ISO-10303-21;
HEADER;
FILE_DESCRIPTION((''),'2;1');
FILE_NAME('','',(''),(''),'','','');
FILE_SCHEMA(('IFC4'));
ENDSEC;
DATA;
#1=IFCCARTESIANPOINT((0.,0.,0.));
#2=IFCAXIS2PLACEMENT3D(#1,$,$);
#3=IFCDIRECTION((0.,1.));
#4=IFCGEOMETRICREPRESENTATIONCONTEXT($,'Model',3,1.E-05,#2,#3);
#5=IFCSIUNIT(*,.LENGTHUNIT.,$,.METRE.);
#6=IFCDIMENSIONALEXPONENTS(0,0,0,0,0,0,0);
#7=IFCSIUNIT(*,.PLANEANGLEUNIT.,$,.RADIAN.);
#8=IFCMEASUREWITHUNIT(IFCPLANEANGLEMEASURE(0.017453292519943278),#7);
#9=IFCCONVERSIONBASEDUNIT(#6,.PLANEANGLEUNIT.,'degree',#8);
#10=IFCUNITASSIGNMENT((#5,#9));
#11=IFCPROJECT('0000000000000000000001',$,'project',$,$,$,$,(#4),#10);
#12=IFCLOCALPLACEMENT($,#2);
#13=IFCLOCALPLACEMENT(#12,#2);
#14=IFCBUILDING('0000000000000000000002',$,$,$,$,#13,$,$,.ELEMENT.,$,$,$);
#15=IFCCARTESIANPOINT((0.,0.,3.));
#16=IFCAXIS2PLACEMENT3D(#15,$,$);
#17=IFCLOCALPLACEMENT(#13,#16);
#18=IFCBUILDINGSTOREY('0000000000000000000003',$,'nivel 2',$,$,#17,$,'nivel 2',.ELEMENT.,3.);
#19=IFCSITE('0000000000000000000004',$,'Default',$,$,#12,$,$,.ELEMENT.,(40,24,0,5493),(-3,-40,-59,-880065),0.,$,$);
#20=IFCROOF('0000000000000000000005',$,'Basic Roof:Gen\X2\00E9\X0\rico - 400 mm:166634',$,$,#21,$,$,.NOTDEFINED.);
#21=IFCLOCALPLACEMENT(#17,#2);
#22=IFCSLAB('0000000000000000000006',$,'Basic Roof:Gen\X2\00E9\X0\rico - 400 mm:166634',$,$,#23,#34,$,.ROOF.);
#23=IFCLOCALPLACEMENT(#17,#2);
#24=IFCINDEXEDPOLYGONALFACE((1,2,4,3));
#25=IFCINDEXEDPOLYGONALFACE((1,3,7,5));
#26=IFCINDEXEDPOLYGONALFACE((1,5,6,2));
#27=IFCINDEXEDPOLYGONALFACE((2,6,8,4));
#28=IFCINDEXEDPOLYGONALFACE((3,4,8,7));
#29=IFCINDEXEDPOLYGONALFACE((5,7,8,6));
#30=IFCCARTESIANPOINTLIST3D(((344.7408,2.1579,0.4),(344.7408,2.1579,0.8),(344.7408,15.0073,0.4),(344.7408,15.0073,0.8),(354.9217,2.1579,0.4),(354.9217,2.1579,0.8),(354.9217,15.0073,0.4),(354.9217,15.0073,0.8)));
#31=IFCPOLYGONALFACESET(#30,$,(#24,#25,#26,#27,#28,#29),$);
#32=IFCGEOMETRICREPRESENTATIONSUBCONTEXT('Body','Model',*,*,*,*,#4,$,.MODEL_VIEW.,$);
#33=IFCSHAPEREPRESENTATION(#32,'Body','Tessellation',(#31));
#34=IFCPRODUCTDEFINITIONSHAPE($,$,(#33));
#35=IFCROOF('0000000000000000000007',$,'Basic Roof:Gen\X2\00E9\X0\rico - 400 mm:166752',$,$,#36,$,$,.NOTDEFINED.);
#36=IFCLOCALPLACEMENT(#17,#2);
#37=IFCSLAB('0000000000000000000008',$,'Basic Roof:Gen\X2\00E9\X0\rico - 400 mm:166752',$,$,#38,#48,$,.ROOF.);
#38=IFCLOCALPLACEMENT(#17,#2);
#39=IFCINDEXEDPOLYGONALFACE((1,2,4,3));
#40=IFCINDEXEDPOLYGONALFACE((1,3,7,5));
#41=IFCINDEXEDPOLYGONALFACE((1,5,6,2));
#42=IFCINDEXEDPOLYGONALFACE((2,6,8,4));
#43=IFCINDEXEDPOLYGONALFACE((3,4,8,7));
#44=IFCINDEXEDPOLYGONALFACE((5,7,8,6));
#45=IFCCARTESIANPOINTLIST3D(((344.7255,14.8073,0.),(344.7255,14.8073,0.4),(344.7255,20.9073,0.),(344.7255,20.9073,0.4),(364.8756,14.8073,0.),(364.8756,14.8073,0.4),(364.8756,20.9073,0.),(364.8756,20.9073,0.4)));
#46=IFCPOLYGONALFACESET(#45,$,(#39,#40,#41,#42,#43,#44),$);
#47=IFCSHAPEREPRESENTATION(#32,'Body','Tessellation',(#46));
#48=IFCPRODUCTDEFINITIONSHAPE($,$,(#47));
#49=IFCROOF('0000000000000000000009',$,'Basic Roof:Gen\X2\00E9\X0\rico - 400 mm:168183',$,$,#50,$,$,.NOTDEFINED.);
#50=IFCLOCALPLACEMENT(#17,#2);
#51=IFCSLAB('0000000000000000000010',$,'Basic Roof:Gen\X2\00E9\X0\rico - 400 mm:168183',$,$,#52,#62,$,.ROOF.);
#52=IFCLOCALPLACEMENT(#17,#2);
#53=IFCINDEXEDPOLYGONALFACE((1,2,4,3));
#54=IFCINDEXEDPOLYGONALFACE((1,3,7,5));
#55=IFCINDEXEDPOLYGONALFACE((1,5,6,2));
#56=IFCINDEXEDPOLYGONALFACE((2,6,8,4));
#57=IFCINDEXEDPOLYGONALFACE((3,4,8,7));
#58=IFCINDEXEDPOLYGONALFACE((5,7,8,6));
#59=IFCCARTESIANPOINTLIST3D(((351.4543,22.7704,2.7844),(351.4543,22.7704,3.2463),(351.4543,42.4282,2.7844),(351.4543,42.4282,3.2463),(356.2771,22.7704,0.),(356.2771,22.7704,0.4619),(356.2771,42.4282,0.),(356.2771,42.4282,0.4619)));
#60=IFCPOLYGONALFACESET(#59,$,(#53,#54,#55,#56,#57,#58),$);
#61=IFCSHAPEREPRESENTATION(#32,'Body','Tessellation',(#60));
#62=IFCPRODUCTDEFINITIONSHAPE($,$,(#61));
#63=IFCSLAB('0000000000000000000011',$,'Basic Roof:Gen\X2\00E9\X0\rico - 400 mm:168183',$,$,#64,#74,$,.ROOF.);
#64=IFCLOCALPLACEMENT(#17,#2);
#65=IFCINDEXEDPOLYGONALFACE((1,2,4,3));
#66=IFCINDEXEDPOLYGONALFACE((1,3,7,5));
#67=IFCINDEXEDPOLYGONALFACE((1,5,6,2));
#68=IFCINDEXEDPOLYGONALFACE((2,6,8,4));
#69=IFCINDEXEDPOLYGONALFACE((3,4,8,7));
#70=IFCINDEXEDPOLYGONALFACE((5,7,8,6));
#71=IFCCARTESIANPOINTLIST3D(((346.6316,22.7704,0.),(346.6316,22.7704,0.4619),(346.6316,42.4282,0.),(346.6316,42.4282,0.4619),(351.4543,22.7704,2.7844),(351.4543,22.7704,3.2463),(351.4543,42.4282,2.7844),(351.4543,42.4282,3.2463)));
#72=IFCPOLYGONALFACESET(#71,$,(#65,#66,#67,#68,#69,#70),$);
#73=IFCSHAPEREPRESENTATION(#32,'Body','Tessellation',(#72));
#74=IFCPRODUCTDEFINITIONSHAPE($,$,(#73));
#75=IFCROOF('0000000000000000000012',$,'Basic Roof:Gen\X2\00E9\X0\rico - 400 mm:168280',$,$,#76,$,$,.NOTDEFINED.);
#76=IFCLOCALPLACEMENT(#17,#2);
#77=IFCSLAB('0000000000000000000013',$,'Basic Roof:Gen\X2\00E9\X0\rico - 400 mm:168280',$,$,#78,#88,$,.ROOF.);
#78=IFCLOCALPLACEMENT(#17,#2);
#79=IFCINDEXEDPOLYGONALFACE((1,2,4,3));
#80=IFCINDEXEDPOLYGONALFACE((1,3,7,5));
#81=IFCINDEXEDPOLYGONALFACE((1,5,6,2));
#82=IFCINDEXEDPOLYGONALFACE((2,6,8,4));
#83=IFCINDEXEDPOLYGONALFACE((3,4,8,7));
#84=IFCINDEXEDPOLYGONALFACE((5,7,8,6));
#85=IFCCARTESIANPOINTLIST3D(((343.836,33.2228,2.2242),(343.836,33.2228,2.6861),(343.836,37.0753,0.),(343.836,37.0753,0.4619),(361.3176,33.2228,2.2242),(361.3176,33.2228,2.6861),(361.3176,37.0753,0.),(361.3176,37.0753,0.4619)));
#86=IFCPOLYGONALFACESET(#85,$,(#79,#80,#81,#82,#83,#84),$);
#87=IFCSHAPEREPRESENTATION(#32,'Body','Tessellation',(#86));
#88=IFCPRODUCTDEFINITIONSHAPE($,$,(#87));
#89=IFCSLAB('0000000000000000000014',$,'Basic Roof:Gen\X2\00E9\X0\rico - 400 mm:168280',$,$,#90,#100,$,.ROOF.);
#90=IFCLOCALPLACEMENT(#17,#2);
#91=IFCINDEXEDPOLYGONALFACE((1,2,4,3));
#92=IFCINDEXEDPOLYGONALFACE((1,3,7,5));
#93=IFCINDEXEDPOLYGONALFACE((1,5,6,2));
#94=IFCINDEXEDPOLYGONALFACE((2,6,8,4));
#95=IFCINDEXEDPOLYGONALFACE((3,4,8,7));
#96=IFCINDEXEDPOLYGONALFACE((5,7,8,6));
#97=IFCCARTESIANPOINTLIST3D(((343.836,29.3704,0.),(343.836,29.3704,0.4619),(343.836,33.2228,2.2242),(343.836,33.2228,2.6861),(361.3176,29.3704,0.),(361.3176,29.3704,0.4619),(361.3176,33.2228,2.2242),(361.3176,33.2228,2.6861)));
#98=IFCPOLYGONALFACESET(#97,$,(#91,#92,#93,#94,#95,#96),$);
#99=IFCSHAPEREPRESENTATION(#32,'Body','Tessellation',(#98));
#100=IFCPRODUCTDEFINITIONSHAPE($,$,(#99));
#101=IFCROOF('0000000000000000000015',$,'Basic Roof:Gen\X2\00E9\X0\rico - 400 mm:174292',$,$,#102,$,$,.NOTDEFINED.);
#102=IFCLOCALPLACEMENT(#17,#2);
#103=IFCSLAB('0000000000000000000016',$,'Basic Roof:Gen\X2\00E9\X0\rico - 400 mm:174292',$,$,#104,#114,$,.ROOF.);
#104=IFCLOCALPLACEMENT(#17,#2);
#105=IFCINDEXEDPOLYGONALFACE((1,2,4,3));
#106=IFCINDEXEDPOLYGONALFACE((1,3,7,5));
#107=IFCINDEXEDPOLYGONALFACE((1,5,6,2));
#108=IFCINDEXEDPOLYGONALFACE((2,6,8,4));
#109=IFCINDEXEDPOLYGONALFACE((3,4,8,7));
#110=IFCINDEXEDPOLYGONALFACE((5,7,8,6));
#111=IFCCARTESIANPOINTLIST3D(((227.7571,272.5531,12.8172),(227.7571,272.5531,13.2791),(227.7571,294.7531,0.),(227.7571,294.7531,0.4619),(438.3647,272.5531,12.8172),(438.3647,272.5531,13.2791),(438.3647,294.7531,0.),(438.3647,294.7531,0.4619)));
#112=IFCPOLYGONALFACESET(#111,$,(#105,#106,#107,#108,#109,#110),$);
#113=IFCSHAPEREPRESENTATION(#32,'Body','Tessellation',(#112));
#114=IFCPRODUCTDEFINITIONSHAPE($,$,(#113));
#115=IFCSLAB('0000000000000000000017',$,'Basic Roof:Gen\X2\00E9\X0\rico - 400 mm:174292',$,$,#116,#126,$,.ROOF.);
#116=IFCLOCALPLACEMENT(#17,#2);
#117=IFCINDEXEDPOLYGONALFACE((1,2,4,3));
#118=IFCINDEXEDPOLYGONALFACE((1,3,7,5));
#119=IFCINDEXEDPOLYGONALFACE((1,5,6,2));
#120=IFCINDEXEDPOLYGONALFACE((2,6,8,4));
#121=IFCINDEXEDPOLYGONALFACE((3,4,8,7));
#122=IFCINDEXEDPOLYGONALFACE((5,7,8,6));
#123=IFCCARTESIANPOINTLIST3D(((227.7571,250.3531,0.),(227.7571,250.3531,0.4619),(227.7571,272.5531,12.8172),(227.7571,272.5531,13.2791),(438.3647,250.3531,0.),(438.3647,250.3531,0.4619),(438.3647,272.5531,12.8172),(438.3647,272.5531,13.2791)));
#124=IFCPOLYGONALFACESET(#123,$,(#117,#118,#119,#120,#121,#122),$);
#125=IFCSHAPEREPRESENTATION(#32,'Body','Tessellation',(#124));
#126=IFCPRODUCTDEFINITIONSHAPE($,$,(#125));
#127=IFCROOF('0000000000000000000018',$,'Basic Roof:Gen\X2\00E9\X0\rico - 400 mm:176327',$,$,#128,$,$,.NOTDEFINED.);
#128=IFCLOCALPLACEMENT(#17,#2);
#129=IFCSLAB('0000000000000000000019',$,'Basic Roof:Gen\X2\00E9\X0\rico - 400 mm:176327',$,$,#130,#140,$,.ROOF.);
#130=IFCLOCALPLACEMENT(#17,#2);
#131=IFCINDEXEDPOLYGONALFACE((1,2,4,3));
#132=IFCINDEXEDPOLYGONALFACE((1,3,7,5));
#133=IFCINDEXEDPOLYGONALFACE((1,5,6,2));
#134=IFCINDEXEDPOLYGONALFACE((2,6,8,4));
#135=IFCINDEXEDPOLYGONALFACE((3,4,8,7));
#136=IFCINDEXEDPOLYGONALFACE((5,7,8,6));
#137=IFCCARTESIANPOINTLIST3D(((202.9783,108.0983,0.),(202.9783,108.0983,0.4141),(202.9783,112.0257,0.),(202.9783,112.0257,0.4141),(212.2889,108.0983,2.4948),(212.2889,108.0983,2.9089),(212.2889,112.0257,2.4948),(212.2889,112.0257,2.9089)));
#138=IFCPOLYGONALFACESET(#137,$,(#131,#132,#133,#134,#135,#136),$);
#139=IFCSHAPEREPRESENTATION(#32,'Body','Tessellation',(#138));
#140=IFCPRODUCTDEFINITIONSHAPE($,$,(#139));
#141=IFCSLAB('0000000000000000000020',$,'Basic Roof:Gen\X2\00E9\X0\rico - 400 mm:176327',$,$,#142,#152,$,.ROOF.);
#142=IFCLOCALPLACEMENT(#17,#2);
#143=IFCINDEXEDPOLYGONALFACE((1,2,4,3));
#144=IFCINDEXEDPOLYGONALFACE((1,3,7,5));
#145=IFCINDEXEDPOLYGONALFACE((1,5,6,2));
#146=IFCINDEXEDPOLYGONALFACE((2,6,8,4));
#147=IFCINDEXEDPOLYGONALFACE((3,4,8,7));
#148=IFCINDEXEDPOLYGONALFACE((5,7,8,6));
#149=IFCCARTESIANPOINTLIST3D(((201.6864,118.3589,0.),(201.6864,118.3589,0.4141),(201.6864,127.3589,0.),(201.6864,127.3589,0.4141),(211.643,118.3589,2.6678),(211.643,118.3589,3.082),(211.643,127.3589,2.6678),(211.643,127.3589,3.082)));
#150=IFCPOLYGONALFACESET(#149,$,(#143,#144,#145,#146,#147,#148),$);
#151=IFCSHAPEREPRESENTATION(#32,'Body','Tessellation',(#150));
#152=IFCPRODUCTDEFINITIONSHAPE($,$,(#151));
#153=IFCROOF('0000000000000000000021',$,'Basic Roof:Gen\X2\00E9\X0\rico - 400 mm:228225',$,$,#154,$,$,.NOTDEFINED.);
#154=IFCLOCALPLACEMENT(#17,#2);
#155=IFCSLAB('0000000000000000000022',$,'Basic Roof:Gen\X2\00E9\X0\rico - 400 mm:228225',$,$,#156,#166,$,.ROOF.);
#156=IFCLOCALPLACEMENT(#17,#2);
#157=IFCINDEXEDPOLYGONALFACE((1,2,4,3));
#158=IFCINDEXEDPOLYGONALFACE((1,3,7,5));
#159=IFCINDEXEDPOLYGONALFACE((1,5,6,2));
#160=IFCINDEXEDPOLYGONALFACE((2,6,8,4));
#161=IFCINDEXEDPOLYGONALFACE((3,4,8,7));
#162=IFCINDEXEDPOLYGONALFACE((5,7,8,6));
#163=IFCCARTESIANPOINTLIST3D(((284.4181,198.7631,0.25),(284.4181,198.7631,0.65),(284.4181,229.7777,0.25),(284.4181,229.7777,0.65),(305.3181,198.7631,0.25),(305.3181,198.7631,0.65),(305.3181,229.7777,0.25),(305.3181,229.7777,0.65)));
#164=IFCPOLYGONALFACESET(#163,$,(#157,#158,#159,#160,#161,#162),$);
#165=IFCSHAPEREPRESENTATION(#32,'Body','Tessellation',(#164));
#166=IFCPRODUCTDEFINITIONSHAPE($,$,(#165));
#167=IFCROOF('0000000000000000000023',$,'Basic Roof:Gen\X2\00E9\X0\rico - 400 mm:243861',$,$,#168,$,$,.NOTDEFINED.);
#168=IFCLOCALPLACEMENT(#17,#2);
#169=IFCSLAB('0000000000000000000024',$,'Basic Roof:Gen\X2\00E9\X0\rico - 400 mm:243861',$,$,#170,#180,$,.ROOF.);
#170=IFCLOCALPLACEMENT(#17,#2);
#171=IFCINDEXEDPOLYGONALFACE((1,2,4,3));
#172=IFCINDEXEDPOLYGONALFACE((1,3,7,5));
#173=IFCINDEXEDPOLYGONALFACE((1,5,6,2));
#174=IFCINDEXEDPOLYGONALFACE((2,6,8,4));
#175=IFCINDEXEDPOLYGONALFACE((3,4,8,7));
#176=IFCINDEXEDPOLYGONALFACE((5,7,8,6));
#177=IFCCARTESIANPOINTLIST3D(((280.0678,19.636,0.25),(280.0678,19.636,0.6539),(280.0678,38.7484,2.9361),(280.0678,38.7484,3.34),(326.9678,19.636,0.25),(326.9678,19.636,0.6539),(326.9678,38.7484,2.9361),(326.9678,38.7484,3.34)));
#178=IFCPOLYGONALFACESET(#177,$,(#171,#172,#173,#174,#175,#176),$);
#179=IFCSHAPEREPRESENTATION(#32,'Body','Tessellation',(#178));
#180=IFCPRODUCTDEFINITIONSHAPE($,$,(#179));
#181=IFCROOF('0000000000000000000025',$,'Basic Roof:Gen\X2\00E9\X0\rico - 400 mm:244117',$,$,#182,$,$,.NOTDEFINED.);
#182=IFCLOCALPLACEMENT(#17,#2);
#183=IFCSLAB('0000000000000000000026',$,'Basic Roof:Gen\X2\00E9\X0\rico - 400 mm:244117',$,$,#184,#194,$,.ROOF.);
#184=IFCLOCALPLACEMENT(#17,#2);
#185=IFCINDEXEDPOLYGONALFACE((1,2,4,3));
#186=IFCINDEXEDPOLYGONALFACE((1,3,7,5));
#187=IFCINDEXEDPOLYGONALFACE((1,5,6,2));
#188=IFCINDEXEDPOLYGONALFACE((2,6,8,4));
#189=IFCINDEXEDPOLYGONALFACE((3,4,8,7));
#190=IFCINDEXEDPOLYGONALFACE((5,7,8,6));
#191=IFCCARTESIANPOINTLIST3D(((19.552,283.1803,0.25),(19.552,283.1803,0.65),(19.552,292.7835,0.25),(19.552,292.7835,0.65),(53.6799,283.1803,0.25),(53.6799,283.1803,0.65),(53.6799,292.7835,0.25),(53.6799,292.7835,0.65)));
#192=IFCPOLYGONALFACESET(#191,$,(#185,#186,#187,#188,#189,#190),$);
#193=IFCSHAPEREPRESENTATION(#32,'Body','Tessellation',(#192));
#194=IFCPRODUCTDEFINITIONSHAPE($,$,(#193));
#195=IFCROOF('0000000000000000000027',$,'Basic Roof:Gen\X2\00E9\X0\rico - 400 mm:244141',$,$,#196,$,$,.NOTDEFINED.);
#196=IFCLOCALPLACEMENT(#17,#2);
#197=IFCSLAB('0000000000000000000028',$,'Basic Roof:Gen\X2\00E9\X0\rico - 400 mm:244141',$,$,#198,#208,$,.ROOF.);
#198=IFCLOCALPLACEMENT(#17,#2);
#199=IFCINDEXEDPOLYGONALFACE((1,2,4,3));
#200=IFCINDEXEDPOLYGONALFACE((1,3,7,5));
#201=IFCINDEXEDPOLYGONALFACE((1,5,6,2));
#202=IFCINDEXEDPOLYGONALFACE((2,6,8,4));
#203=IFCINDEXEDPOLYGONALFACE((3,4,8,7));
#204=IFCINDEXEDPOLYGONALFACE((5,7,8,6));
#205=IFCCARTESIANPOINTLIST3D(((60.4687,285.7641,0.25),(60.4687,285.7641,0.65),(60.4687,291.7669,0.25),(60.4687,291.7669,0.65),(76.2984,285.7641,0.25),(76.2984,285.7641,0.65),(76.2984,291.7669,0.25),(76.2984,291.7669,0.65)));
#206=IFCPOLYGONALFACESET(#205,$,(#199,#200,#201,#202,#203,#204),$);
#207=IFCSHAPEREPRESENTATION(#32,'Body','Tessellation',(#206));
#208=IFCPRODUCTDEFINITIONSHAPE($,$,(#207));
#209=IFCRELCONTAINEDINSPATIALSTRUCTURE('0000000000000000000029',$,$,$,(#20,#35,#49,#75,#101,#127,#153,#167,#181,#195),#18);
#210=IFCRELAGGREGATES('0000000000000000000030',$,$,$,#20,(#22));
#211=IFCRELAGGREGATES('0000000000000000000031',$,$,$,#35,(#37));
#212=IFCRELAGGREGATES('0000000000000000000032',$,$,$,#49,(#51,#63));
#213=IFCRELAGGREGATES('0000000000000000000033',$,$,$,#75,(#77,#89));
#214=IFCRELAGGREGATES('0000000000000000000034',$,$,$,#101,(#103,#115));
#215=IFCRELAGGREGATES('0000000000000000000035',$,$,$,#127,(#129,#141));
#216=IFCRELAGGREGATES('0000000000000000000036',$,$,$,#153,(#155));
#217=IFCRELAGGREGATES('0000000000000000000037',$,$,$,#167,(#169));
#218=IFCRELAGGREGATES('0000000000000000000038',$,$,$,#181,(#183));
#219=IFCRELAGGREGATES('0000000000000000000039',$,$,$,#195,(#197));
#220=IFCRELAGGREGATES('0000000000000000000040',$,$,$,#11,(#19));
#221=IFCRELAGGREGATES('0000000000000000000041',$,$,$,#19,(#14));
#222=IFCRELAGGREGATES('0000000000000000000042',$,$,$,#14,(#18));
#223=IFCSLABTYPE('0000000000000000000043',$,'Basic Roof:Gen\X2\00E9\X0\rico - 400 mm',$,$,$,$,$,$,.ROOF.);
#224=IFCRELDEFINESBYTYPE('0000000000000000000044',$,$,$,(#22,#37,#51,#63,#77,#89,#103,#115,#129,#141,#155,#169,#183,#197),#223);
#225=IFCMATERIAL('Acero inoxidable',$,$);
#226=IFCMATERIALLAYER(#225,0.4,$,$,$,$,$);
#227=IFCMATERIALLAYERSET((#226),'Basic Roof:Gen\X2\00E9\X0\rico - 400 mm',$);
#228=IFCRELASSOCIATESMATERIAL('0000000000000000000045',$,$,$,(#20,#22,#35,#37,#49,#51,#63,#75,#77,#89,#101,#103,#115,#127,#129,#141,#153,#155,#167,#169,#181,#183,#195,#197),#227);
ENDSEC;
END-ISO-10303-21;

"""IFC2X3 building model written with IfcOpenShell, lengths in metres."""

from ifc_helpers import new_model, entity, si_unit, converted_unit, direction, frame, frame_2d, origin, place, context, subcontext, project, spatial, rectangle, extrude, material, layer, layer_set, type_object, element, aggregate, save


model = new_model("IFC2X3")

# Units and contexts
model_context = context("Model", 3, precision=1e-05, world=origin(), true_north=direction((0.0, 1.0)))
body_context = subcontext(model_context, "Body", "Model", "MODEL_VIEW")
ifc_project = project(units=[si_unit("LENGTHUNIT", "METRE"), converted_unit("PLANEANGLEUNIT", "degree", entity("IfcPlaneAngleMeasure", 0.017453292519943278), si_unit("PLANEANGLEUNIT", "RADIAN"), dimensions=[0, 0, 0, 0, 0, 0, 0])], contexts=[model_context])

# Site, building, storey
site_placement = place(None, origin())
site = spatial("IfcSite", under=ifc_project, at=site_placement, Name="Default", CompositionType="ELEMENT", RefLatitude=(40, 24, 0, 5493), RefLongitude=(-3, -40, -59, -880065), RefElevation=0.0)
building_placement = place(site_placement, origin())
building = spatial("IfcBuilding", under=site, at=building_placement, CompositionType="ELEMENT")
storey_placement = place(building_placement, frame((0.0, 0.0, 3.0)))
storey = spatial("IfcBuildingStorey", under=building, at=storey_placement, Name="nivel 2", LongName="nivel 2", CompositionType="ELEMENT", Elevation=3.0)

# Roofs, slabs
ifc_material_1 = material(Name="Acero inoxidable")
ifc_layer_1 = layer(ifc_material_1, 0.4)
ifc_layer_set_1 = layer_set([ifc_layer_1], Name="Basic Roof:Genérico - 400 mm")
roof_1_placement = place(storey_placement, frame((344.7408, 2.1579, 0.4)))
roof_1 = element("IfcRoof", 1, at=roof_1_placement, inside=storey, material=ifc_layer_set_1, Name="Basic Roof:Genérico - 400 mm:166634", ShapeType="NOTDEFINED")
slab_type = type_object("IfcSlabType", Name="Basic Roof:Genérico - 400 mm", PredefinedType="ROOF")
slab_1_placement = place(roof_1_placement, origin())
slab_1 = element("IfcSlab", 2, at=slab_1_placement, type_object=slab_type, material=ifc_layer_set_1, Name="Basic Roof:Genérico - 400 mm:166634", PredefinedType="ROOF", context=body_context, shape_type="SweptSolid", body=[
    extrude(rectangle(XDim=10.1809, YDim=12.8494, at=frame_2d((0.0, 0.0), x_axis=(-1.0, 0.0))), frame((5.0905, 6.4247, 0.0)), (0.0, 0.0, 1.0), 0.4),
])
aggregate(roof_1, [slab_1])
roof_2_placement = place(storey_placement, frame((344.7255, 14.8073, 0.0)))
roof_2 = element("IfcRoof", 3, at=roof_2_placement, inside=storey, material=ifc_layer_set_1, Name="Basic Roof:Genérico - 400 mm:166752", ShapeType="NOTDEFINED")
slab_2_placement = place(roof_2_placement, origin())
slab_2 = element("IfcSlab", 4, at=slab_2_placement, type_object=slab_type, material=ifc_layer_set_1, Name="Basic Roof:Genérico - 400 mm:166752", PredefinedType="ROOF", context=body_context, shape_type="SweptSolid", body=[
    extrude(rectangle(XDim=6.1, YDim=20.1501, at=frame_2d((0.0, 0.0), x_axis=(0.0, 1.0))), frame((10.075, 3.05, 0.0)), (0.0, 0.0, 1.0), 0.4),
])
aggregate(roof_2, [slab_2])

# Roofs, slabs
roof_3_placement = place(storey_placement, frame((346.6316, 22.7704, 0.0)))
roof_3 = element("IfcRoof", 5, at=roof_3_placement, inside=storey, material=ifc_layer_set_1, Name="Basic Roof:Genérico - 400 mm:168183", ShapeType="NOTDEFINED")
slab_3_placement = place(roof_3_placement, origin())
slab_3 = element("IfcSlab", 6, at=slab_3_placement, type_object=slab_type, material=ifc_layer_set_1, Name="Basic Roof:Genérico - 400 mm:168183", PredefinedType="ROOF", context=body_context, shape_type="SweptSolid", body=[
    extrude(rectangle(XDim=5.5689, YDim=19.6577, at=frame_2d((0.0, 0.0), x_axis=(1.0, 0.0))), frame((7.2342, 9.8289, 1.3922), z_axis=(0.5, 0.0, 0.866025), x_axis=(0.866025, 0.0, -0.5)), (-0.5, 0.0, 0.866025), 0.4619),
])
slab_4_placement = place(roof_3_placement, origin())
slab_4 = element("IfcSlab", 7, at=slab_4_placement, type_object=slab_type, material=ifc_layer_set_1, Name="Basic Roof:Genérico - 400 mm:168183", PredefinedType="ROOF", context=body_context, shape_type="SweptSolid", body=[
    extrude(rectangle(XDim=19.6577, YDim=5.5689, at=frame_2d((0.0, 0.0), x_axis=(0.0, 1.0))), frame((2.4114, 9.8289, 1.3922), z_axis=(-0.5, 0.0, 0.866025), x_axis=(0.866025, 0.0, 0.5)), (0.5, 0.0, 0.866025), 0.4619),
])
aggregate(roof_3, [slab_3, slab_4])
roof_4_placement = place(storey_placement, frame((343.836, 29.3704, 0.0)))
roof_4 = element("IfcRoof", 8, at=roof_4_placement, inside=storey, material=ifc_layer_set_1, Name="Basic Roof:Genérico - 400 mm:168280", ShapeType="NOTDEFINED")
slab_5_placement = place(roof_4_placement, origin())
slab_5 = element("IfcSlab", 9, at=slab_5_placement, type_object=slab_type, material=ifc_layer_set_1, Name="Basic Roof:Genérico - 400 mm:168280", PredefinedType="ROOF", context=body_context, shape_type="SweptSolid", body=[
    extrude(rectangle(XDim=17.4816, YDim=4.4484, at=frame_2d((0.0, 0.0), x_axis=(1.0, 0.0))), frame((8.7408, 5.7786, 1.1121), z_axis=(0.0, 0.5, 0.866025), x_axis=(1.0, 0.0, 0.0)), (0.0, -0.5, 0.866025), 0.4619),
])
slab_6_placement = place(roof_4_placement, origin())
slab_6 = element("IfcSlab", 10, at=slab_6_placement, type_object=slab_type, material=ifc_layer_set_1, Name="Basic Roof:Genérico - 400 mm:168280", PredefinedType="ROOF", context=body_context, shape_type="SweptSolid", body=[
    extrude(rectangle(XDim=4.4484, YDim=17.4816, at=frame_2d((0.0, 0.0), x_axis=(0.0, 1.0))), frame((8.7408, 1.9262, 1.1121), z_axis=(0.0, -0.5, 0.866025), x_axis=(1.0, 0.0, 0.0)), (0.0, 0.5, 0.866025), 0.4619),
])
aggregate(roof_4, [slab_5, slab_6])
roof_5_placement = place(storey_placement, frame((227.7571, 250.3531, 0.0)))
roof_5 = element("IfcRoof", 11, at=roof_5_placement, inside=storey, material=ifc_layer_set_1, Name="Basic Roof:Genérico - 400 mm:174292", ShapeType="NOTDEFINED")
slab_7_placement = place(roof_5_placement, origin())
slab_7 = element("IfcSlab", 12, at=slab_7_placement, type_object=slab_type, material=ifc_layer_set_1, Name="Basic Roof:Genérico - 400 mm:174292", PredefinedType="ROOF", context=body_context, shape_type="SweptSolid", body=[
    extrude(rectangle(XDim=210.6076, YDim=25.6344, at=frame_2d((0.0, 0.0), x_axis=(1.0, 0.0))), frame((105.3038, 33.3, 6.4086), z_axis=(0.0, 0.5, 0.866025), x_axis=(1.0, 0.0, 0.0)), (0.0, -0.5, 0.866025), 0.4619),
])
slab_8_placement = place(roof_5_placement, origin())
slab_8 = element("IfcSlab", 13, at=slab_8_placement, type_object=slab_type, material=ifc_layer_set_1, Name="Basic Roof:Genérico - 400 mm:174292", PredefinedType="ROOF", context=body_context, shape_type="SweptSolid", body=[
    extrude(rectangle(XDim=25.6344, YDim=210.6076, at=frame_2d((0.0, 0.0), x_axis=(0.0, 1.0))), frame((105.3038, 11.1, 6.4086), z_axis=(0.0, -0.5, 0.866025), x_axis=(1.0, 0.0, 0.0)), (0.0, 0.5, 0.866025), 0.4619),
])
aggregate(roof_5, [slab_7, slab_8])
roof_6_placement = place(storey_placement, frame((201.6864, 108.0983, 0.0)))
roof_6 = element("IfcRoof", 14, at=roof_6_placement, inside=storey, material=ifc_layer_set_1, Name="Basic Roof:Genérico - 400 mm:176327", ShapeType="NOTDEFINED")
slab_9_placement = place(roof_6_placement, origin())
slab_9 = element("IfcSlab", 15, at=slab_9_placement, type_object=slab_type, material=ifc_layer_set_1, Name="Basic Roof:Genérico - 400 mm:176327", PredefinedType="ROOF", context=body_context, shape_type="SweptSolid", body=[
    extrude(rectangle(XDim=9.639, YDim=3.9274, at=frame_2d((0.0, 0.0), x_axis=(1.0, 0.0))), frame((5.9472, 1.9637, 1.2474), z_axis=(-0.258819, 0.0, 0.965926), x_axis=(0.965926, 0.0, 0.258819)), (0.258819, 0.0, 0.965926), 0.4141),
])
slab_10_placement = place(roof_6_placement, origin())
slab_10 = element("IfcSlab", 16, at=slab_10_placement, type_object=slab_type, material=ifc_layer_set_1, Name="Basic Roof:Genérico - 400 mm:176327", PredefinedType="ROOF", context=body_context, shape_type="SweptSolid", body=[
    extrude(rectangle(XDim=10.3078, YDim=9.0, at=frame_2d((0.0, 0.0), x_axis=(1.0, 0.0))), frame((4.9783, 14.7606, 1.3339), z_axis=(-0.258819, 0.0, 0.965926), x_axis=(0.965926, 0.0, 0.258819)), (0.258819, 0.0, 0.965926), 0.4141),
])
aggregate(roof_6, [slab_9, slab_10])

# Roofs, slabs
roof_7_placement = place(storey_placement, frame((284.4181, 198.7631, 0.25)))
roof_7 = element("IfcRoof", 17, at=roof_7_placement, inside=storey, material=ifc_layer_set_1, Name="Basic Roof:Genérico - 400 mm:228225", ShapeType="NOTDEFINED")
slab_11_placement = place(roof_7_placement, origin())
slab_11 = element("IfcSlab", 18, at=slab_11_placement, type_object=slab_type, material=ifc_layer_set_1, Name="Basic Roof:Genérico - 400 mm:228225", PredefinedType="ROOF", context=body_context, shape_type="SweptSolid", body=[
    extrude(rectangle(XDim=31.0146, YDim=20.9, at=frame_2d((0.0, 0.0), x_axis=(0.0, -1.0))), frame((10.45, 15.5073, 0.0)), (0.0, 0.0, 1.0), 0.4),
])
aggregate(roof_7, [slab_11])
roof_8_placement = place(storey_placement, frame((280.0678, 19.636, 0.25)))
roof_8 = element("IfcRoof", 19, at=roof_8_placement, inside=storey, material=ifc_layer_set_1, Name="Basic Roof:Genérico - 400 mm:243861", ShapeType="NOTDEFINED")
slab_12_placement = place(roof_8_placement, origin())
slab_12 = element("IfcSlab", 20, at=slab_12_placement, type_object=slab_type, material=ifc_layer_set_1, Name="Basic Roof:Genérico - 400 mm:243861", PredefinedType="ROOF", context=body_context, shape_type="SweptSolid", body=[
    extrude(rectangle(XDim=46.9, YDim=19.3002, at=frame_2d((0.0, 0.0), x_axis=(1.0, 0.0))), frame((23.45, 9.5562, 1.343), z_axis=(0.0, -0.139173, 0.990268), x_axis=(1.0, 0.0, 0.0)), (0.0, 0.139173, 0.990268), 0.4039),
])
aggregate(roof_8, [slab_12])
roof_9_placement = place(storey_placement, frame((19.552, 283.1803, 0.25)))
roof_9 = element("IfcRoof", 21, at=roof_9_placement, inside=storey, material=ifc_layer_set_1, Name="Basic Roof:Genérico - 400 mm:244117", ShapeType="NOTDEFINED")
slab_13_placement = place(roof_9_placement, origin())
slab_13 = element("IfcSlab", 22, at=slab_13_placement, type_object=slab_type, material=ifc_layer_set_1, Name="Basic Roof:Genérico - 400 mm:244117", PredefinedType="ROOF", context=body_context, shape_type="SweptSolid", body=[
    extrude(rectangle(XDim=9.6032, YDim=34.1278, at=frame_2d((0.0, 0.0), x_axis=(0.0, 1.0))), frame((17.0639, 4.8016, 0.0)), (0.0, 0.0, 1.0), 0.4),
])
aggregate(roof_9, [slab_13])
roof_10_placement = place(storey_placement, frame((60.4687, 285.7641, 0.25)))
roof_10 = element("IfcRoof", 23, at=roof_10_placement, inside=storey, material=ifc_layer_set_1, Name="Basic Roof:Genérico - 400 mm:244141", ShapeType="NOTDEFINED")
slab_14_placement = place(roof_10_placement, origin())
slab_14 = element("IfcSlab", 24, at=slab_14_placement, type_object=slab_type, material=ifc_layer_set_1, Name="Basic Roof:Genérico - 400 mm:244141", PredefinedType="ROOF", context=body_context, shape_type="SweptSolid", body=[
    extrude(rectangle(XDim=6.0029, YDim=15.8297, at=frame_2d((0.0, 0.0), x_axis=(0.0, 1.0))), frame((7.9148, 3.0014, 0.0)), (0.0, 0.0, 1.0), 0.4),
])
aggregate(roof_10, [slab_14])

save(model, "model.ifc")
